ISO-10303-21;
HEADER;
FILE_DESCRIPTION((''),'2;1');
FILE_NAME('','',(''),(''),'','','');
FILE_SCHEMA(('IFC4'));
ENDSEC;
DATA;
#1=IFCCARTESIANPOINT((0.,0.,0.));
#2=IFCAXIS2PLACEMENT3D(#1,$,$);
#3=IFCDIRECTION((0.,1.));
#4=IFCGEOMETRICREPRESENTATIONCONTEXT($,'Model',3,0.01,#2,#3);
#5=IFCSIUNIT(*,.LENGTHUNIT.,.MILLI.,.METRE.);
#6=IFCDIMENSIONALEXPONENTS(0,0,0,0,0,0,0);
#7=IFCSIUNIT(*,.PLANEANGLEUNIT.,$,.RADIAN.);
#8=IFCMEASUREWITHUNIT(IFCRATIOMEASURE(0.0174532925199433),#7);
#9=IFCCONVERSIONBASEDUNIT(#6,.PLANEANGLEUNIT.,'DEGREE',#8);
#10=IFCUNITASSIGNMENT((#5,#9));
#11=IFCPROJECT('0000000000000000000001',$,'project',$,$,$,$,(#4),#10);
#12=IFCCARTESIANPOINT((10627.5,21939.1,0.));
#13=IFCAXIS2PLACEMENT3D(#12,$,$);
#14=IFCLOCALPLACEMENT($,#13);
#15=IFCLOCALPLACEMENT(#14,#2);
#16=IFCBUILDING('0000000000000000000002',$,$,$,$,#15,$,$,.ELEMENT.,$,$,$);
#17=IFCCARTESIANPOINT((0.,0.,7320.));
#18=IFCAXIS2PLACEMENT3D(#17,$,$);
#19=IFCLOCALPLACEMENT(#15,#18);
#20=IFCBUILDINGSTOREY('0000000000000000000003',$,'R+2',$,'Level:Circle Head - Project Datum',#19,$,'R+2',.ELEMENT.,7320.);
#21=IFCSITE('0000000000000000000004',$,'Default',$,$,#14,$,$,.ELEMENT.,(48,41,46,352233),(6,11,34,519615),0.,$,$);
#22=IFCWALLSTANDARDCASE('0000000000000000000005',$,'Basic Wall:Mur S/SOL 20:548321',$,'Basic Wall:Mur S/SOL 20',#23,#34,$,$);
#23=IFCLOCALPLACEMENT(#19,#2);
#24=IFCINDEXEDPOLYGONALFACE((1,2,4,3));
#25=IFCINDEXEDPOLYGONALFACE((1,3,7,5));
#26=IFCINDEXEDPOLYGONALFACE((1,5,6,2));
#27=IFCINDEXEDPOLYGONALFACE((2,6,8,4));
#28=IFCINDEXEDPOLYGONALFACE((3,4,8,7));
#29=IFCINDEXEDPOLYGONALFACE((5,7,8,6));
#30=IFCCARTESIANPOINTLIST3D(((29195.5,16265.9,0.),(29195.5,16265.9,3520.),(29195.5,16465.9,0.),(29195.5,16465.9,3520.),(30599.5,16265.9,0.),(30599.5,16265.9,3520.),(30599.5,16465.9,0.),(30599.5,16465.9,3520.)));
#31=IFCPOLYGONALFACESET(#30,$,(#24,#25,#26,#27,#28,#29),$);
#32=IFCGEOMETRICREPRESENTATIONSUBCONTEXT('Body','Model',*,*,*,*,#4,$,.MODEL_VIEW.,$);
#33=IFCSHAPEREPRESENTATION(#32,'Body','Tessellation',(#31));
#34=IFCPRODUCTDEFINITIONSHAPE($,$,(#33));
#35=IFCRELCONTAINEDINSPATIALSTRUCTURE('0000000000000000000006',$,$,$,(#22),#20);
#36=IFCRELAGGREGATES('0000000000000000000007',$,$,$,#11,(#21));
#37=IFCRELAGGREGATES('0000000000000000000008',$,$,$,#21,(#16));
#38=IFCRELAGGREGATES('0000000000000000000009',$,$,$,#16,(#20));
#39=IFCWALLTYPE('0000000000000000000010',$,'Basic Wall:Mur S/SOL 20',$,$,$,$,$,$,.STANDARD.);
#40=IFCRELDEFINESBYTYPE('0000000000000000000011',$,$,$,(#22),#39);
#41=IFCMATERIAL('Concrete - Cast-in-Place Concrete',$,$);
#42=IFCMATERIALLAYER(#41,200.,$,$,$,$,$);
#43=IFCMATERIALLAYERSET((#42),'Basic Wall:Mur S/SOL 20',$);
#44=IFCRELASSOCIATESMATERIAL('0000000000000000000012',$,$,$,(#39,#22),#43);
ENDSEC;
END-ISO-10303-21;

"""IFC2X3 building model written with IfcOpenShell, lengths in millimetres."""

from ifc_helpers import new_model, entity, si_unit, converted_unit, direction, frame, frame_2d, origin, place, context, subcontext, project, spatial, rectangle, extrude, material, layer, layer_set, layer_usage, type_object, element, save


model = new_model("IFC2X3")

# Units and contexts
model_context = context("Model", 3, precision=0.01, world=origin(), true_north=direction((0.0, 1.0)))
body_context = subcontext(model_context, "Body", "Model", "MODEL_VIEW")
ifc_project = project(units=[si_unit("LENGTHUNIT", "METRE", prefix="MILLI"), converted_unit("PLANEANGLEUNIT", "DEGREE", entity("IfcRatioMeasure", 0.0174532925199433), si_unit("PLANEANGLEUNIT", "RADIAN"), dimensions=[0, 0, 0, 0, 0, 0, 0])], contexts=[model_context])

# Site, building, storey
site_placement = place(None, frame((10627.5, 21939.1, 0.0)))
site = spatial("IfcSite", under=ifc_project, at=site_placement, Name="Default", CompositionType="ELEMENT", RefLatitude=(48, 41, 46, 352233), RefLongitude=(6, 11, 34, 519615), RefElevation=0.0)
building_placement = place(site_placement, origin())
building = spatial("IfcBuilding", under=site, at=building_placement, CompositionType="ELEMENT")
storey_placement = place(building_placement, frame((0.0, 0.0, 7320.0)))
storey = spatial("IfcBuildingStorey", under=building, at=storey_placement, Name="R+2", ObjectType="Level:Circle Head - Project Datum", LongName="R+2", CompositionType="ELEMENT", Elevation=7320.0)

# Wall
ifc_material_1 = material(Name="Concrete - Cast-in-Place Concrete")
ifc_layer = layer(ifc_material_1, 200.0)
ifc_layer_set = layer_set([ifc_layer], Name="Basic Wall:Mur S/SOL 20")
ifc_layer_usage = layer_usage(ifc_layer_set, "AXIS2", "POSITIVE", -100.0)
wall_type = type_object("IfcWallType", Name="Basic Wall:Mur S/SOL 20", PredefinedType="STANDARD", material=ifc_layer_set)
wall_placement = place(storey_placement, frame((29195.5, 16365.9, 0.0)))
element("IfcWallStandardCase", 1, at=wall_placement, inside=storey, type_object=wall_type, material=ifc_layer_usage, Name="Basic Wall:Mur S/SOL 20:548321", ObjectType="Basic Wall:Mur S/SOL 20", context=body_context, shape_type="SweptSolid", body=[
    extrude(rectangle(XDim=1404.0, YDim=200.0, at=frame_2d((702.0, 0.0), x_axis=(-1.0, 0.0))), origin(), (0.0, 0.0, 1.0), 3520.0),
])

save(model, "model.ifc")
